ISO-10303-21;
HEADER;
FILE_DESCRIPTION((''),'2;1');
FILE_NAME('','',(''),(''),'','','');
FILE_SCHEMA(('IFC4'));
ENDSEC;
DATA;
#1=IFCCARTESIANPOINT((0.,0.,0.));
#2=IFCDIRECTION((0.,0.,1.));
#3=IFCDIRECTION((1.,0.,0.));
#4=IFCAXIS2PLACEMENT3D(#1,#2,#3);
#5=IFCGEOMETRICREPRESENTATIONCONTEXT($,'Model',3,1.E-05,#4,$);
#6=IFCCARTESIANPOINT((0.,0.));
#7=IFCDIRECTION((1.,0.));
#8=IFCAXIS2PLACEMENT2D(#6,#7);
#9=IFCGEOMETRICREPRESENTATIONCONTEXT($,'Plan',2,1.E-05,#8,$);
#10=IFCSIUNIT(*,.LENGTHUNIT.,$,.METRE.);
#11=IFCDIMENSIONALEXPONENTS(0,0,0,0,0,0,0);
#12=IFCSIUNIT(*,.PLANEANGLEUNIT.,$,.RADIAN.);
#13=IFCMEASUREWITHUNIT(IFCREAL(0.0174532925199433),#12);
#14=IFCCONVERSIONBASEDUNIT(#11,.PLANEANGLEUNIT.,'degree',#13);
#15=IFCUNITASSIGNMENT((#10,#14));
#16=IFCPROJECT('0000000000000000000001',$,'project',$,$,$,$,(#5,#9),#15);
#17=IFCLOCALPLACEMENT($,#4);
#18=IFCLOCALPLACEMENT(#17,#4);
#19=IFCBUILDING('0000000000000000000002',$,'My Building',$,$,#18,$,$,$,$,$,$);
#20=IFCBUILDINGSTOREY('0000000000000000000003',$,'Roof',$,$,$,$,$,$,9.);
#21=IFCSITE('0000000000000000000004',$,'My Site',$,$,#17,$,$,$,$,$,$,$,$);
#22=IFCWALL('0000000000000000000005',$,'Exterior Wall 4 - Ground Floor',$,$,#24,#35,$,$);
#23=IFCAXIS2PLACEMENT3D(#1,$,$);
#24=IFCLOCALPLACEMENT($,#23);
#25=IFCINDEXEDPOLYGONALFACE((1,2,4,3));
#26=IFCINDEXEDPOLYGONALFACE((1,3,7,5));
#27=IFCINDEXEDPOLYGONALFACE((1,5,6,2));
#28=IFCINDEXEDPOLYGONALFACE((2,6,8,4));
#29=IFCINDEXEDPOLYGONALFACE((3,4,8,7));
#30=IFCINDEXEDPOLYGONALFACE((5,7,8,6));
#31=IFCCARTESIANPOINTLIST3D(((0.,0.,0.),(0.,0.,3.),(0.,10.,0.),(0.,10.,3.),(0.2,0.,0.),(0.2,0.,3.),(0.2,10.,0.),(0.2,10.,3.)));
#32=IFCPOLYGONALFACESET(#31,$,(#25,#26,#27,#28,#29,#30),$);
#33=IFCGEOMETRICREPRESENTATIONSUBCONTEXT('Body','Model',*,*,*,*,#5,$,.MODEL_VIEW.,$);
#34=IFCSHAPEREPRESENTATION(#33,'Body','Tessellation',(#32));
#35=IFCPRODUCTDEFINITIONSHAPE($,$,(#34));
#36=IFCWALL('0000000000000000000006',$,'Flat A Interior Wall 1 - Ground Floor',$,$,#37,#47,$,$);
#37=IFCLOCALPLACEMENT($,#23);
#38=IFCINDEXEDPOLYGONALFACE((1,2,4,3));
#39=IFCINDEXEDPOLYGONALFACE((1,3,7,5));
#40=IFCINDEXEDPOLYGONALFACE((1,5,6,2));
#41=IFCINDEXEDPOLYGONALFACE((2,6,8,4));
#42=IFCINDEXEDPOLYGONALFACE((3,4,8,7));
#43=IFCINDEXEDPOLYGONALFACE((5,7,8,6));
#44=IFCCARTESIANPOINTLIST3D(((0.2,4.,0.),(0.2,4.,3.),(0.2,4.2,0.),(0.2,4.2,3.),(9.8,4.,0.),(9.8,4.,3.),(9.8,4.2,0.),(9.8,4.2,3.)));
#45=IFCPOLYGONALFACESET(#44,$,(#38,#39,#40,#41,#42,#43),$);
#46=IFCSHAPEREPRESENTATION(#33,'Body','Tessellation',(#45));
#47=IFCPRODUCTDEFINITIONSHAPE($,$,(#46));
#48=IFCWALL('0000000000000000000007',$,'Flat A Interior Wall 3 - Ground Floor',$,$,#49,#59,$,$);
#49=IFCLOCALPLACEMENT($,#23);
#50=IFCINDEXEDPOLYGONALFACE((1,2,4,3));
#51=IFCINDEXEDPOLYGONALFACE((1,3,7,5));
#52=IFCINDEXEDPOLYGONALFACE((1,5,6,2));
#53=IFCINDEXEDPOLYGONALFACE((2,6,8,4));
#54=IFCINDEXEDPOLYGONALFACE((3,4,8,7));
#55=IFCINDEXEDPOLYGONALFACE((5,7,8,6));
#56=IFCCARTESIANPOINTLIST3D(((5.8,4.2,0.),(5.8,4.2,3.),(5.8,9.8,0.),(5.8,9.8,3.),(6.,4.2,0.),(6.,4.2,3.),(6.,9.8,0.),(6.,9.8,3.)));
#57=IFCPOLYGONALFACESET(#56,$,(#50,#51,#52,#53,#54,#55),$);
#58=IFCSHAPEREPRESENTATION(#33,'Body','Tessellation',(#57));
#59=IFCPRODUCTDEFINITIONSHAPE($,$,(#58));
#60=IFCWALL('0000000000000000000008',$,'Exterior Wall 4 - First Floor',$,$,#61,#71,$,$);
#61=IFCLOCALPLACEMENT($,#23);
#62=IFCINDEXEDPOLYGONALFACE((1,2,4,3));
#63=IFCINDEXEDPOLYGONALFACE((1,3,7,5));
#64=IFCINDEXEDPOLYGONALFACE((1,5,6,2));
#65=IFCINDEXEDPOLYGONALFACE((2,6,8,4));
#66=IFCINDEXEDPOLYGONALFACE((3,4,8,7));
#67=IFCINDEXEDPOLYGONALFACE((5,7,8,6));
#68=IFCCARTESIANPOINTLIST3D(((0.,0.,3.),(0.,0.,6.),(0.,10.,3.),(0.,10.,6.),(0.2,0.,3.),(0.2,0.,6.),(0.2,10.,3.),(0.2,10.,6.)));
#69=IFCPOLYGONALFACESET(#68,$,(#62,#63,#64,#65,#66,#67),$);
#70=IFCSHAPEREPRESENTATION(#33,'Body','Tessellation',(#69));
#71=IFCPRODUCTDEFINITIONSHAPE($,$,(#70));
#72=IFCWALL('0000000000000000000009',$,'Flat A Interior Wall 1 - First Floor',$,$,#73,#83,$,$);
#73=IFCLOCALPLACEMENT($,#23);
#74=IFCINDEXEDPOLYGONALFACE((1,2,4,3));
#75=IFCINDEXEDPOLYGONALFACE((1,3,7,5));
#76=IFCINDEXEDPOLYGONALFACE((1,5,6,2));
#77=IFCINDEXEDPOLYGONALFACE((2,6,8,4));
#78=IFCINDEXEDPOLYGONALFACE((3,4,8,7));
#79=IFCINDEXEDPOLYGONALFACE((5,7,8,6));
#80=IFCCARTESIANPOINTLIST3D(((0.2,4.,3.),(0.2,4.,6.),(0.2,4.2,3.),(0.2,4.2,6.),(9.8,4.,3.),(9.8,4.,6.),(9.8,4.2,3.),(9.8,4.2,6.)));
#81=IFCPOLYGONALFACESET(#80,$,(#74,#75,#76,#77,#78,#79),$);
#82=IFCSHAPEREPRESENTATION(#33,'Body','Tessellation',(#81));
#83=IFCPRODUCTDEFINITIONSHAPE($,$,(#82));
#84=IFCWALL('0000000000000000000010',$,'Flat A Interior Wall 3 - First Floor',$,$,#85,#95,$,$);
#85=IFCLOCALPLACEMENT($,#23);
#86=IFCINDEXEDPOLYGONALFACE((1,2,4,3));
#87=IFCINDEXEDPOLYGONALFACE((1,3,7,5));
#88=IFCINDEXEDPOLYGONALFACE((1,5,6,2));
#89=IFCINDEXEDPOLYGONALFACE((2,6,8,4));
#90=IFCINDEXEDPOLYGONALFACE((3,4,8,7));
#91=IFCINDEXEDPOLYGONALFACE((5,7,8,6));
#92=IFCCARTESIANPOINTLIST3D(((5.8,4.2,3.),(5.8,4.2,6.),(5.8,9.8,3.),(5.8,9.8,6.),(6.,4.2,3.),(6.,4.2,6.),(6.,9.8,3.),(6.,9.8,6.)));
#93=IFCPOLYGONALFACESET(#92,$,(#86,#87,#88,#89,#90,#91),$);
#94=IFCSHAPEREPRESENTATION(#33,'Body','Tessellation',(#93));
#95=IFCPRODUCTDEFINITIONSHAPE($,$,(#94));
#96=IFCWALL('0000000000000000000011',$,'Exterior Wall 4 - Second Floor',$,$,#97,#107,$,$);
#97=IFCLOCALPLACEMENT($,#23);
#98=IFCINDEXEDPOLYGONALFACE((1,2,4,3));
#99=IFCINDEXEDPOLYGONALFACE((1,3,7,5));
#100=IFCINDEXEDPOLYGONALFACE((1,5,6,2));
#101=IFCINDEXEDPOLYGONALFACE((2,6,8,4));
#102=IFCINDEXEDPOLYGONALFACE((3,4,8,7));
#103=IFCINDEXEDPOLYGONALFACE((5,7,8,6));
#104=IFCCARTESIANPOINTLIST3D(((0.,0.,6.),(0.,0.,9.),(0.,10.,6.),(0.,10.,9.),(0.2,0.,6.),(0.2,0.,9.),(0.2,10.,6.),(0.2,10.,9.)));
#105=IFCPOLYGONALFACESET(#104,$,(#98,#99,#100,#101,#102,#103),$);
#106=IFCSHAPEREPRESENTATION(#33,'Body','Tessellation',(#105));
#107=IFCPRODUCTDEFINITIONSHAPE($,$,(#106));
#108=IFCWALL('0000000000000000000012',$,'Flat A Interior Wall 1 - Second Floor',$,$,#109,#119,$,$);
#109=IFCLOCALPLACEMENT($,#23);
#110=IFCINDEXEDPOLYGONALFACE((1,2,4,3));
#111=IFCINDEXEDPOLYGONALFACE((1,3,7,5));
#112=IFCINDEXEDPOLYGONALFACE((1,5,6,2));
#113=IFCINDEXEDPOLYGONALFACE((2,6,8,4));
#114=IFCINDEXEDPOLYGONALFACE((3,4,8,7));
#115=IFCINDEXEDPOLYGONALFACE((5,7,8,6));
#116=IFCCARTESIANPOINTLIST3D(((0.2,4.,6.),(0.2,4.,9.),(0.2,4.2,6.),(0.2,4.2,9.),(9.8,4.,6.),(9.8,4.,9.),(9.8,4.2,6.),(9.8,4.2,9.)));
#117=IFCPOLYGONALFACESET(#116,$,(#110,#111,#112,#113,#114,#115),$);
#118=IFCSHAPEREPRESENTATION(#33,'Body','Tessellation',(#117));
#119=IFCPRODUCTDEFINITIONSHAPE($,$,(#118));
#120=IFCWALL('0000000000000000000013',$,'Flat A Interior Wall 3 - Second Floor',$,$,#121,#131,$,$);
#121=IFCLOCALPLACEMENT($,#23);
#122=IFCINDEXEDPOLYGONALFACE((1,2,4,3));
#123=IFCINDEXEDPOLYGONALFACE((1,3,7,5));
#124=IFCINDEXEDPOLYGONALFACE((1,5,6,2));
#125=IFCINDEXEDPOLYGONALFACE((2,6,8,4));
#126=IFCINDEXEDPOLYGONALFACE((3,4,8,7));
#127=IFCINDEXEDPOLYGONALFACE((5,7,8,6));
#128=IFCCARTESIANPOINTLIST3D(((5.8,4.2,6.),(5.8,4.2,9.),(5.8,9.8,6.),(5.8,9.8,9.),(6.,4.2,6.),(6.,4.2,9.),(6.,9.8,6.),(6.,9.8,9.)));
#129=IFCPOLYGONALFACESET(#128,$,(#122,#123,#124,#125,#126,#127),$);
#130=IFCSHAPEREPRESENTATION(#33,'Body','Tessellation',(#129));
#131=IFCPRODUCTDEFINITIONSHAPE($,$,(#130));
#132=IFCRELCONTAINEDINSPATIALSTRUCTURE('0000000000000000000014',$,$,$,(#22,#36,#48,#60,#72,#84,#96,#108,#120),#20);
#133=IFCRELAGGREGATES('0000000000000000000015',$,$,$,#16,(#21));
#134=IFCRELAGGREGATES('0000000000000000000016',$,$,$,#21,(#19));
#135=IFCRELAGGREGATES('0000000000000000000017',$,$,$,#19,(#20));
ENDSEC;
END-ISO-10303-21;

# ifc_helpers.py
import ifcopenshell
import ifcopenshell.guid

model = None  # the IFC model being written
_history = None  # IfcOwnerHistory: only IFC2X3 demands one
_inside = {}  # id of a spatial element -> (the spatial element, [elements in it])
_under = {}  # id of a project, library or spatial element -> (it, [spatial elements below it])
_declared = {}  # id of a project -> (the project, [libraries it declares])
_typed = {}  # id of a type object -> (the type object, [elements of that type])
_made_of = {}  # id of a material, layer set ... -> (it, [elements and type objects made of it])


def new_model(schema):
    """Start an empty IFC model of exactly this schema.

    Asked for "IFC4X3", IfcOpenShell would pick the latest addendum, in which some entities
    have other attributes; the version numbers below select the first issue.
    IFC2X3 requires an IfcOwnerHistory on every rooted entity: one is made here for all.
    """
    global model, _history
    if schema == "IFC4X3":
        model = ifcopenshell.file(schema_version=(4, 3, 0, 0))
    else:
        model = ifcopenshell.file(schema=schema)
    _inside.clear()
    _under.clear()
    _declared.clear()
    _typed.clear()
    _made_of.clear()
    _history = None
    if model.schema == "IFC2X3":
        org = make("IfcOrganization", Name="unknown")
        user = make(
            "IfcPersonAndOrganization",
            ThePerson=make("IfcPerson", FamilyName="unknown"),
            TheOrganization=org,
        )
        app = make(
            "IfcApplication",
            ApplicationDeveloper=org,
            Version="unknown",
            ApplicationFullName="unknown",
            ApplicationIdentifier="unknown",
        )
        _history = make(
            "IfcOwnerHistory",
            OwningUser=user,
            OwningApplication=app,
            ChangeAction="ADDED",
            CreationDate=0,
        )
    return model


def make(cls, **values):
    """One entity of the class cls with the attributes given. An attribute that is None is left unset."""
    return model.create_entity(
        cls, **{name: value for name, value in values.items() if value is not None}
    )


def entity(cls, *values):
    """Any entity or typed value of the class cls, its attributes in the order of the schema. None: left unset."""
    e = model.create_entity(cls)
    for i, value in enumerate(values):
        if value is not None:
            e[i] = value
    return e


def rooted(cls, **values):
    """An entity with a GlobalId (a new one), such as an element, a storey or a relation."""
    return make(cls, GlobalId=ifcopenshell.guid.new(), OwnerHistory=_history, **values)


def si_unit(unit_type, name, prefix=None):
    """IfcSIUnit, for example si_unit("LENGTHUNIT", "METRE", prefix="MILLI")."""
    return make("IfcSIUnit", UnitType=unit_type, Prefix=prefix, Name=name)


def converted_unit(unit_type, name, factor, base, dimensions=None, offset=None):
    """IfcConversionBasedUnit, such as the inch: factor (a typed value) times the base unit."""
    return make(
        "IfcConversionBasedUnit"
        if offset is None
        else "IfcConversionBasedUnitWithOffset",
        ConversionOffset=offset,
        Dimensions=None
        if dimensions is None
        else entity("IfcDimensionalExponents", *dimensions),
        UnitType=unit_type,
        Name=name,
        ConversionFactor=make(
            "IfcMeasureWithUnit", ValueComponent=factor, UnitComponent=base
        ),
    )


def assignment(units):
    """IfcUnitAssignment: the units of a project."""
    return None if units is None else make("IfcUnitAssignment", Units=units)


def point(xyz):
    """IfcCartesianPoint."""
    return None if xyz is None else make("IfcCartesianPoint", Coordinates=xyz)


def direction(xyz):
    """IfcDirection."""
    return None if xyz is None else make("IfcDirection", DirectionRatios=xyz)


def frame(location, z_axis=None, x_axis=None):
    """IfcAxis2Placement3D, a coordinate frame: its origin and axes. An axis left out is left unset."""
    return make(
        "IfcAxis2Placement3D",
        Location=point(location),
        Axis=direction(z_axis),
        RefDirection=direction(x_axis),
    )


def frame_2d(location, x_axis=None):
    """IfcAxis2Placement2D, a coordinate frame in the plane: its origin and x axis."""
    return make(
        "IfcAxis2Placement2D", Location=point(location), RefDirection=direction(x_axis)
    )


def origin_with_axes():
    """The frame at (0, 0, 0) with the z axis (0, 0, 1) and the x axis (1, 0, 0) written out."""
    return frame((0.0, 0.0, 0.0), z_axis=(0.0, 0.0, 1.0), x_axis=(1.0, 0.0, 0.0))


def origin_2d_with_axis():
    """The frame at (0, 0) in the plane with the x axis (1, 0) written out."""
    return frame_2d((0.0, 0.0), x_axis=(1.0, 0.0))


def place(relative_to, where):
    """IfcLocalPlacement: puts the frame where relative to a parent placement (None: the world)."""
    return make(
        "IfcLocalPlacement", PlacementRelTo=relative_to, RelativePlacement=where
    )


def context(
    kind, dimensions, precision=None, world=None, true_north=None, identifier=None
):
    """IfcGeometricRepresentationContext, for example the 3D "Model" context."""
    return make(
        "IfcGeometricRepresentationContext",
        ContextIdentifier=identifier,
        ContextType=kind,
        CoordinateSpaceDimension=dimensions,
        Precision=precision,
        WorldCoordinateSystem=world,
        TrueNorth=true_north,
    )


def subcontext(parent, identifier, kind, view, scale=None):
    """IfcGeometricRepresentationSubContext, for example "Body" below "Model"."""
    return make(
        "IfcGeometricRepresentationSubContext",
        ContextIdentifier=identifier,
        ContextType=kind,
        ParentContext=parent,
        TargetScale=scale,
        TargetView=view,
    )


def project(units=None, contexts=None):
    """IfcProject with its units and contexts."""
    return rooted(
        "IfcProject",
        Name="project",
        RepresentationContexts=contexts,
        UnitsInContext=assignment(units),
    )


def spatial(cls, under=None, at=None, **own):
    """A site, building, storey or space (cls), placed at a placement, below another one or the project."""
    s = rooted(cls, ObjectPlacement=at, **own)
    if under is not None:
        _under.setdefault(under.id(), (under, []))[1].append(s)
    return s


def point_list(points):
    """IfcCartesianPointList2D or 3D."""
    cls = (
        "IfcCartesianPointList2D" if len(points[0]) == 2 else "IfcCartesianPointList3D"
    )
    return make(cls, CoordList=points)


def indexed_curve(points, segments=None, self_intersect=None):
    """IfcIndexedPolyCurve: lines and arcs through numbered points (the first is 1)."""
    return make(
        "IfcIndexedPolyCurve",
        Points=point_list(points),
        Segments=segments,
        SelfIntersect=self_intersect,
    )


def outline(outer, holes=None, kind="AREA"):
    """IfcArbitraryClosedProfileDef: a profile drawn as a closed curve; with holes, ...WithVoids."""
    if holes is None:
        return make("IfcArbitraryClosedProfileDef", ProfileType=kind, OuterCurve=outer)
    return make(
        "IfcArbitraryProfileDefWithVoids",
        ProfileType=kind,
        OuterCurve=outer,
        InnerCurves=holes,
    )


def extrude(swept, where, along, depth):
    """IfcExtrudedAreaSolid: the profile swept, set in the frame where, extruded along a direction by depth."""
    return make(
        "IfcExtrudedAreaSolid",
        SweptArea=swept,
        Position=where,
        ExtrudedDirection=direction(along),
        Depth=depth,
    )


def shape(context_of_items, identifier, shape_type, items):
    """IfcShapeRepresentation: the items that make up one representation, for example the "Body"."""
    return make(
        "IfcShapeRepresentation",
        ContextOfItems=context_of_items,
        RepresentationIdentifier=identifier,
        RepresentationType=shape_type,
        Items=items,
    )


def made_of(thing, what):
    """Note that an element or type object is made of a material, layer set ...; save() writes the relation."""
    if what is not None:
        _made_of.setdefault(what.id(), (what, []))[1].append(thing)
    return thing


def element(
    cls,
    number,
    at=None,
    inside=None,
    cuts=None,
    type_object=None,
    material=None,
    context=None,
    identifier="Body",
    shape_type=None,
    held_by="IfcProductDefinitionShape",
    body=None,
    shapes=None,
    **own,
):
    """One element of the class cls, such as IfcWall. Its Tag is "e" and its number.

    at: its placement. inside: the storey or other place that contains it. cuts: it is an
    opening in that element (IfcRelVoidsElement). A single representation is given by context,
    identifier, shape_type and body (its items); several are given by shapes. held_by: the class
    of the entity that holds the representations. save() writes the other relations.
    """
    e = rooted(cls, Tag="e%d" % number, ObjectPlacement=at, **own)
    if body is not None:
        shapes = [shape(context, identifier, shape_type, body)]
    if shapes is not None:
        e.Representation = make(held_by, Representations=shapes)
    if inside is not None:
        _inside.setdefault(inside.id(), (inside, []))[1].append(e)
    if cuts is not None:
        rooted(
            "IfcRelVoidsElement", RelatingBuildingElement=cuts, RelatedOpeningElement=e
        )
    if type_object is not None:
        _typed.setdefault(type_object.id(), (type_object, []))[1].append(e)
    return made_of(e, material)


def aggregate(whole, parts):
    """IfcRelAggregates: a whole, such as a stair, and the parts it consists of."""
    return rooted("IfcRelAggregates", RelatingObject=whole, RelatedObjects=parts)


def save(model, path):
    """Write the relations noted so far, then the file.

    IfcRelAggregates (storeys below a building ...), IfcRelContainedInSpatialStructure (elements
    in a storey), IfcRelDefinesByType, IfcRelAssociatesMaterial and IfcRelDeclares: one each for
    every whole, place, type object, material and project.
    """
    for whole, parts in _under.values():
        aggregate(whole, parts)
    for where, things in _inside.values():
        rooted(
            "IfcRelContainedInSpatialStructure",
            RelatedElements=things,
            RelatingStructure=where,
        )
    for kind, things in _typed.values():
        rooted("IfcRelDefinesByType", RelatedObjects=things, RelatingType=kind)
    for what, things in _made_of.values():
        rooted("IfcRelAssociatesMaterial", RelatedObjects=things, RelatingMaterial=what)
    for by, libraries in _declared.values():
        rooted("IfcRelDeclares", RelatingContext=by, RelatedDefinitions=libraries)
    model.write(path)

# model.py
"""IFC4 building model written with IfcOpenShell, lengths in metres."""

from ifc_helpers import new_model, entity, si_unit, converted_unit, frame, origin_with_axes, origin_2d_with_axis, place, context, subcontext, project, spatial, indexed_curve, outline, extrude, element, save


model = new_model("IFC4")

# Units and contexts
model_context = context("Model", 3, precision=1e-05, world=origin_with_axes())
plan_context = context("Plan", 2, precision=1e-05, world=origin_2d_with_axis())
body_context = subcontext(model_context, "Body", "Model", "MODEL_VIEW")
ifc_project = project(units=[si_unit("LENGTHUNIT", "METRE"), converted_unit("PLANEANGLEUNIT", "degree", entity("IfcReal", 0.0174532925199433), si_unit("PLANEANGLEUNIT", "RADIAN"), dimensions=[0, 0, 0, 0, 0, 0, 0])], contexts=[model_context, plan_context])

# Site, building, storey
site_placement = place(None, origin_with_axes())
site = spatial("IfcSite", under=ifc_project, at=site_placement, Name="My Site")
building_placement = place(site_placement, origin_with_axes())
building = spatial("IfcBuilding", under=site, at=building_placement, Name="My Building")
storey = spatial("IfcBuildingStorey", under=building, Name="Roof", Elevation=9.0)

# Walls
wall_1_placement = place(None, frame((0.0, 10.0, 0.0), z_axis=(0.0, 0.0, 1.0), x_axis=(0.0, -1.0, 0.0)))
element("IfcWall", 1, at=wall_1_placement, inside=storey, Name="Exterior Wall 4 - Ground Floor", context=body_context, shape_type="SweptSolid", body=[
    extrude(outline(indexed_curve([(0.0, 0.0), (0.0, 0.2), (10.0, 0.2), (10.0, 0.0), (0.0, 0.0)], self_intersect=False)), origin_with_axes(), (0.0, 0.0, 1.0), 3.0),
])
wall_2_placement = place(None, frame((0.2, 4.0, 0.0), z_axis=(0.0, 0.0, 1.0), x_axis=(1.0, 0.0, 0.0)))
element("IfcWall", 2, at=wall_2_placement, inside=storey, Name="Flat A Interior Wall 1 - Ground Floor", context=body_context, shape_type="SweptSolid", body=[
    extrude(outline(indexed_curve([(0.0, 0.0), (0.0, 0.2), (9.6, 0.2), (9.6, 0.0), (0.0, 0.0)], self_intersect=False)), origin_with_axes(), (0.0, 0.0, 1.0), 3.0),
])
wall_3_placement = place(None, frame((6.0, 4.2, 0.0), z_axis=(0.0, 0.0, 1.0), x_axis=(0.0, 1.0, 0.0)))
element("IfcWall", 3, at=wall_3_placement, inside=storey, Name="Flat A Interior Wall 3 - Ground Floor", context=body_context, shape_type="SweptSolid", body=[
    extrude(outline(indexed_curve([(0.0, 0.0), (0.0, 0.2), (5.6, 0.2), (5.6, 0.0), (0.0, 0.0)], self_intersect=False)), origin_with_axes(), (0.0, 0.0, 1.0), 3.0),
])
wall_4_placement = place(None, frame((0.0, 10.0, 3.0), z_axis=(0.0, 0.0, 1.0), x_axis=(0.0, -1.0, 0.0)))
element("IfcWall", 4, at=wall_4_placement, inside=storey, Name="Exterior Wall 4 - First Floor", context=body_context, shape_type="SweptSolid", body=[
    extrude(outline(indexed_curve([(0.0, 0.0), (0.0, 0.2), (10.0, 0.2), (10.0, 0.0), (0.0, 0.0)], self_intersect=False)), origin_with_axes(), (0.0, 0.0, 1.0), 3.0),
])
wall_5_placement = place(None, frame((0.2, 4.0, 3.0), z_axis=(0.0, 0.0, 1.0), x_axis=(1.0, 0.0, 0.0)))
element("IfcWall", 5, at=wall_5_placement, inside=storey, Name="Flat A Interior Wall 1 - First Floor", context=body_context, shape_type="SweptSolid", body=[
    extrude(outline(indexed_curve([(0.0, 0.0), (0.0, 0.2), (9.6, 0.2), (9.6, 0.0), (0.0, 0.0)], self_intersect=False)), origin_with_axes(), (0.0, 0.0, 1.0), 3.0),
])
wall_6_placement = place(None, frame((6.0, 4.2, 3.0), z_axis=(0.0, 0.0, 1.0), x_axis=(0.0, 1.0, 0.0)))
element("IfcWall", 6, at=wall_6_placement, inside=storey, Name="Flat A Interior Wall 3 - First Floor", context=body_context, shape_type="SweptSolid", body=[
    extrude(outline(indexed_curve([(0.0, 0.0), (0.0, 0.2), (5.6, 0.2), (5.6, 0.0), (0.0, 0.0)], self_intersect=False)), origin_with_axes(), (0.0, 0.0, 1.0), 3.0),
])
wall_7_placement = place(None, frame((0.0, 10.0, 6.0), z_axis=(0.0, 0.0, 1.0), x_axis=(0.0, -1.0, 0.0)))
element("IfcWall", 7, at=wall_7_placement, inside=storey, Name="Exterior Wall 4 - Second Floor", context=body_context, shape_type="SweptSolid", body=[
    extrude(outline(indexed_curve([(0.0, 0.0), (0.0, 0.2), (10.0, 0.2), (10.0, 0.0), (0.0, 0.0)], self_intersect=False)), origin_with_axes(), (0.0, 0.0, 1.0), 3.0),
])
wall_8_placement = place(None, frame((0.2, 4.0, 6.0), z_axis=(0.0, 0.0, 1.0), x_axis=(1.0, 0.0, 0.0)))
element("IfcWall", 8, at=wall_8_placement, inside=storey, Name="Flat A Interior Wall 1 - Second Floor", context=body_context, shape_type="SweptSolid", body=[
    extrude(outline(indexed_curve([(0.0, 0.0), (0.0, 0.2), (9.6, 0.2), (9.6, 0.0), (0.0, 0.0)], self_intersect=False)), origin_with_axes(), (0.0, 0.0, 1.0), 3.0),
])
wall_9_placement = place(None, frame((6.0, 4.2, 6.0), z_axis=(0.0, 0.0, 1.0), x_axis=(0.0, 1.0, 0.0)))
element("IfcWall", 9, at=wall_9_placement, inside=storey, Name="Flat A Interior Wall 3 - Second Floor", context=body_context, shape_type="SweptSolid", body=[
    extrude(outline(indexed_curve([(0.0, 0.0), (0.0, 0.2), (5.6, 0.2), (5.6, 0.0), (0.0, 0.0)], self_intersect=False)), origin_with_axes(), (0.0, 0.0, 1.0), 3.0),
])

save(model, "model.ifc")
